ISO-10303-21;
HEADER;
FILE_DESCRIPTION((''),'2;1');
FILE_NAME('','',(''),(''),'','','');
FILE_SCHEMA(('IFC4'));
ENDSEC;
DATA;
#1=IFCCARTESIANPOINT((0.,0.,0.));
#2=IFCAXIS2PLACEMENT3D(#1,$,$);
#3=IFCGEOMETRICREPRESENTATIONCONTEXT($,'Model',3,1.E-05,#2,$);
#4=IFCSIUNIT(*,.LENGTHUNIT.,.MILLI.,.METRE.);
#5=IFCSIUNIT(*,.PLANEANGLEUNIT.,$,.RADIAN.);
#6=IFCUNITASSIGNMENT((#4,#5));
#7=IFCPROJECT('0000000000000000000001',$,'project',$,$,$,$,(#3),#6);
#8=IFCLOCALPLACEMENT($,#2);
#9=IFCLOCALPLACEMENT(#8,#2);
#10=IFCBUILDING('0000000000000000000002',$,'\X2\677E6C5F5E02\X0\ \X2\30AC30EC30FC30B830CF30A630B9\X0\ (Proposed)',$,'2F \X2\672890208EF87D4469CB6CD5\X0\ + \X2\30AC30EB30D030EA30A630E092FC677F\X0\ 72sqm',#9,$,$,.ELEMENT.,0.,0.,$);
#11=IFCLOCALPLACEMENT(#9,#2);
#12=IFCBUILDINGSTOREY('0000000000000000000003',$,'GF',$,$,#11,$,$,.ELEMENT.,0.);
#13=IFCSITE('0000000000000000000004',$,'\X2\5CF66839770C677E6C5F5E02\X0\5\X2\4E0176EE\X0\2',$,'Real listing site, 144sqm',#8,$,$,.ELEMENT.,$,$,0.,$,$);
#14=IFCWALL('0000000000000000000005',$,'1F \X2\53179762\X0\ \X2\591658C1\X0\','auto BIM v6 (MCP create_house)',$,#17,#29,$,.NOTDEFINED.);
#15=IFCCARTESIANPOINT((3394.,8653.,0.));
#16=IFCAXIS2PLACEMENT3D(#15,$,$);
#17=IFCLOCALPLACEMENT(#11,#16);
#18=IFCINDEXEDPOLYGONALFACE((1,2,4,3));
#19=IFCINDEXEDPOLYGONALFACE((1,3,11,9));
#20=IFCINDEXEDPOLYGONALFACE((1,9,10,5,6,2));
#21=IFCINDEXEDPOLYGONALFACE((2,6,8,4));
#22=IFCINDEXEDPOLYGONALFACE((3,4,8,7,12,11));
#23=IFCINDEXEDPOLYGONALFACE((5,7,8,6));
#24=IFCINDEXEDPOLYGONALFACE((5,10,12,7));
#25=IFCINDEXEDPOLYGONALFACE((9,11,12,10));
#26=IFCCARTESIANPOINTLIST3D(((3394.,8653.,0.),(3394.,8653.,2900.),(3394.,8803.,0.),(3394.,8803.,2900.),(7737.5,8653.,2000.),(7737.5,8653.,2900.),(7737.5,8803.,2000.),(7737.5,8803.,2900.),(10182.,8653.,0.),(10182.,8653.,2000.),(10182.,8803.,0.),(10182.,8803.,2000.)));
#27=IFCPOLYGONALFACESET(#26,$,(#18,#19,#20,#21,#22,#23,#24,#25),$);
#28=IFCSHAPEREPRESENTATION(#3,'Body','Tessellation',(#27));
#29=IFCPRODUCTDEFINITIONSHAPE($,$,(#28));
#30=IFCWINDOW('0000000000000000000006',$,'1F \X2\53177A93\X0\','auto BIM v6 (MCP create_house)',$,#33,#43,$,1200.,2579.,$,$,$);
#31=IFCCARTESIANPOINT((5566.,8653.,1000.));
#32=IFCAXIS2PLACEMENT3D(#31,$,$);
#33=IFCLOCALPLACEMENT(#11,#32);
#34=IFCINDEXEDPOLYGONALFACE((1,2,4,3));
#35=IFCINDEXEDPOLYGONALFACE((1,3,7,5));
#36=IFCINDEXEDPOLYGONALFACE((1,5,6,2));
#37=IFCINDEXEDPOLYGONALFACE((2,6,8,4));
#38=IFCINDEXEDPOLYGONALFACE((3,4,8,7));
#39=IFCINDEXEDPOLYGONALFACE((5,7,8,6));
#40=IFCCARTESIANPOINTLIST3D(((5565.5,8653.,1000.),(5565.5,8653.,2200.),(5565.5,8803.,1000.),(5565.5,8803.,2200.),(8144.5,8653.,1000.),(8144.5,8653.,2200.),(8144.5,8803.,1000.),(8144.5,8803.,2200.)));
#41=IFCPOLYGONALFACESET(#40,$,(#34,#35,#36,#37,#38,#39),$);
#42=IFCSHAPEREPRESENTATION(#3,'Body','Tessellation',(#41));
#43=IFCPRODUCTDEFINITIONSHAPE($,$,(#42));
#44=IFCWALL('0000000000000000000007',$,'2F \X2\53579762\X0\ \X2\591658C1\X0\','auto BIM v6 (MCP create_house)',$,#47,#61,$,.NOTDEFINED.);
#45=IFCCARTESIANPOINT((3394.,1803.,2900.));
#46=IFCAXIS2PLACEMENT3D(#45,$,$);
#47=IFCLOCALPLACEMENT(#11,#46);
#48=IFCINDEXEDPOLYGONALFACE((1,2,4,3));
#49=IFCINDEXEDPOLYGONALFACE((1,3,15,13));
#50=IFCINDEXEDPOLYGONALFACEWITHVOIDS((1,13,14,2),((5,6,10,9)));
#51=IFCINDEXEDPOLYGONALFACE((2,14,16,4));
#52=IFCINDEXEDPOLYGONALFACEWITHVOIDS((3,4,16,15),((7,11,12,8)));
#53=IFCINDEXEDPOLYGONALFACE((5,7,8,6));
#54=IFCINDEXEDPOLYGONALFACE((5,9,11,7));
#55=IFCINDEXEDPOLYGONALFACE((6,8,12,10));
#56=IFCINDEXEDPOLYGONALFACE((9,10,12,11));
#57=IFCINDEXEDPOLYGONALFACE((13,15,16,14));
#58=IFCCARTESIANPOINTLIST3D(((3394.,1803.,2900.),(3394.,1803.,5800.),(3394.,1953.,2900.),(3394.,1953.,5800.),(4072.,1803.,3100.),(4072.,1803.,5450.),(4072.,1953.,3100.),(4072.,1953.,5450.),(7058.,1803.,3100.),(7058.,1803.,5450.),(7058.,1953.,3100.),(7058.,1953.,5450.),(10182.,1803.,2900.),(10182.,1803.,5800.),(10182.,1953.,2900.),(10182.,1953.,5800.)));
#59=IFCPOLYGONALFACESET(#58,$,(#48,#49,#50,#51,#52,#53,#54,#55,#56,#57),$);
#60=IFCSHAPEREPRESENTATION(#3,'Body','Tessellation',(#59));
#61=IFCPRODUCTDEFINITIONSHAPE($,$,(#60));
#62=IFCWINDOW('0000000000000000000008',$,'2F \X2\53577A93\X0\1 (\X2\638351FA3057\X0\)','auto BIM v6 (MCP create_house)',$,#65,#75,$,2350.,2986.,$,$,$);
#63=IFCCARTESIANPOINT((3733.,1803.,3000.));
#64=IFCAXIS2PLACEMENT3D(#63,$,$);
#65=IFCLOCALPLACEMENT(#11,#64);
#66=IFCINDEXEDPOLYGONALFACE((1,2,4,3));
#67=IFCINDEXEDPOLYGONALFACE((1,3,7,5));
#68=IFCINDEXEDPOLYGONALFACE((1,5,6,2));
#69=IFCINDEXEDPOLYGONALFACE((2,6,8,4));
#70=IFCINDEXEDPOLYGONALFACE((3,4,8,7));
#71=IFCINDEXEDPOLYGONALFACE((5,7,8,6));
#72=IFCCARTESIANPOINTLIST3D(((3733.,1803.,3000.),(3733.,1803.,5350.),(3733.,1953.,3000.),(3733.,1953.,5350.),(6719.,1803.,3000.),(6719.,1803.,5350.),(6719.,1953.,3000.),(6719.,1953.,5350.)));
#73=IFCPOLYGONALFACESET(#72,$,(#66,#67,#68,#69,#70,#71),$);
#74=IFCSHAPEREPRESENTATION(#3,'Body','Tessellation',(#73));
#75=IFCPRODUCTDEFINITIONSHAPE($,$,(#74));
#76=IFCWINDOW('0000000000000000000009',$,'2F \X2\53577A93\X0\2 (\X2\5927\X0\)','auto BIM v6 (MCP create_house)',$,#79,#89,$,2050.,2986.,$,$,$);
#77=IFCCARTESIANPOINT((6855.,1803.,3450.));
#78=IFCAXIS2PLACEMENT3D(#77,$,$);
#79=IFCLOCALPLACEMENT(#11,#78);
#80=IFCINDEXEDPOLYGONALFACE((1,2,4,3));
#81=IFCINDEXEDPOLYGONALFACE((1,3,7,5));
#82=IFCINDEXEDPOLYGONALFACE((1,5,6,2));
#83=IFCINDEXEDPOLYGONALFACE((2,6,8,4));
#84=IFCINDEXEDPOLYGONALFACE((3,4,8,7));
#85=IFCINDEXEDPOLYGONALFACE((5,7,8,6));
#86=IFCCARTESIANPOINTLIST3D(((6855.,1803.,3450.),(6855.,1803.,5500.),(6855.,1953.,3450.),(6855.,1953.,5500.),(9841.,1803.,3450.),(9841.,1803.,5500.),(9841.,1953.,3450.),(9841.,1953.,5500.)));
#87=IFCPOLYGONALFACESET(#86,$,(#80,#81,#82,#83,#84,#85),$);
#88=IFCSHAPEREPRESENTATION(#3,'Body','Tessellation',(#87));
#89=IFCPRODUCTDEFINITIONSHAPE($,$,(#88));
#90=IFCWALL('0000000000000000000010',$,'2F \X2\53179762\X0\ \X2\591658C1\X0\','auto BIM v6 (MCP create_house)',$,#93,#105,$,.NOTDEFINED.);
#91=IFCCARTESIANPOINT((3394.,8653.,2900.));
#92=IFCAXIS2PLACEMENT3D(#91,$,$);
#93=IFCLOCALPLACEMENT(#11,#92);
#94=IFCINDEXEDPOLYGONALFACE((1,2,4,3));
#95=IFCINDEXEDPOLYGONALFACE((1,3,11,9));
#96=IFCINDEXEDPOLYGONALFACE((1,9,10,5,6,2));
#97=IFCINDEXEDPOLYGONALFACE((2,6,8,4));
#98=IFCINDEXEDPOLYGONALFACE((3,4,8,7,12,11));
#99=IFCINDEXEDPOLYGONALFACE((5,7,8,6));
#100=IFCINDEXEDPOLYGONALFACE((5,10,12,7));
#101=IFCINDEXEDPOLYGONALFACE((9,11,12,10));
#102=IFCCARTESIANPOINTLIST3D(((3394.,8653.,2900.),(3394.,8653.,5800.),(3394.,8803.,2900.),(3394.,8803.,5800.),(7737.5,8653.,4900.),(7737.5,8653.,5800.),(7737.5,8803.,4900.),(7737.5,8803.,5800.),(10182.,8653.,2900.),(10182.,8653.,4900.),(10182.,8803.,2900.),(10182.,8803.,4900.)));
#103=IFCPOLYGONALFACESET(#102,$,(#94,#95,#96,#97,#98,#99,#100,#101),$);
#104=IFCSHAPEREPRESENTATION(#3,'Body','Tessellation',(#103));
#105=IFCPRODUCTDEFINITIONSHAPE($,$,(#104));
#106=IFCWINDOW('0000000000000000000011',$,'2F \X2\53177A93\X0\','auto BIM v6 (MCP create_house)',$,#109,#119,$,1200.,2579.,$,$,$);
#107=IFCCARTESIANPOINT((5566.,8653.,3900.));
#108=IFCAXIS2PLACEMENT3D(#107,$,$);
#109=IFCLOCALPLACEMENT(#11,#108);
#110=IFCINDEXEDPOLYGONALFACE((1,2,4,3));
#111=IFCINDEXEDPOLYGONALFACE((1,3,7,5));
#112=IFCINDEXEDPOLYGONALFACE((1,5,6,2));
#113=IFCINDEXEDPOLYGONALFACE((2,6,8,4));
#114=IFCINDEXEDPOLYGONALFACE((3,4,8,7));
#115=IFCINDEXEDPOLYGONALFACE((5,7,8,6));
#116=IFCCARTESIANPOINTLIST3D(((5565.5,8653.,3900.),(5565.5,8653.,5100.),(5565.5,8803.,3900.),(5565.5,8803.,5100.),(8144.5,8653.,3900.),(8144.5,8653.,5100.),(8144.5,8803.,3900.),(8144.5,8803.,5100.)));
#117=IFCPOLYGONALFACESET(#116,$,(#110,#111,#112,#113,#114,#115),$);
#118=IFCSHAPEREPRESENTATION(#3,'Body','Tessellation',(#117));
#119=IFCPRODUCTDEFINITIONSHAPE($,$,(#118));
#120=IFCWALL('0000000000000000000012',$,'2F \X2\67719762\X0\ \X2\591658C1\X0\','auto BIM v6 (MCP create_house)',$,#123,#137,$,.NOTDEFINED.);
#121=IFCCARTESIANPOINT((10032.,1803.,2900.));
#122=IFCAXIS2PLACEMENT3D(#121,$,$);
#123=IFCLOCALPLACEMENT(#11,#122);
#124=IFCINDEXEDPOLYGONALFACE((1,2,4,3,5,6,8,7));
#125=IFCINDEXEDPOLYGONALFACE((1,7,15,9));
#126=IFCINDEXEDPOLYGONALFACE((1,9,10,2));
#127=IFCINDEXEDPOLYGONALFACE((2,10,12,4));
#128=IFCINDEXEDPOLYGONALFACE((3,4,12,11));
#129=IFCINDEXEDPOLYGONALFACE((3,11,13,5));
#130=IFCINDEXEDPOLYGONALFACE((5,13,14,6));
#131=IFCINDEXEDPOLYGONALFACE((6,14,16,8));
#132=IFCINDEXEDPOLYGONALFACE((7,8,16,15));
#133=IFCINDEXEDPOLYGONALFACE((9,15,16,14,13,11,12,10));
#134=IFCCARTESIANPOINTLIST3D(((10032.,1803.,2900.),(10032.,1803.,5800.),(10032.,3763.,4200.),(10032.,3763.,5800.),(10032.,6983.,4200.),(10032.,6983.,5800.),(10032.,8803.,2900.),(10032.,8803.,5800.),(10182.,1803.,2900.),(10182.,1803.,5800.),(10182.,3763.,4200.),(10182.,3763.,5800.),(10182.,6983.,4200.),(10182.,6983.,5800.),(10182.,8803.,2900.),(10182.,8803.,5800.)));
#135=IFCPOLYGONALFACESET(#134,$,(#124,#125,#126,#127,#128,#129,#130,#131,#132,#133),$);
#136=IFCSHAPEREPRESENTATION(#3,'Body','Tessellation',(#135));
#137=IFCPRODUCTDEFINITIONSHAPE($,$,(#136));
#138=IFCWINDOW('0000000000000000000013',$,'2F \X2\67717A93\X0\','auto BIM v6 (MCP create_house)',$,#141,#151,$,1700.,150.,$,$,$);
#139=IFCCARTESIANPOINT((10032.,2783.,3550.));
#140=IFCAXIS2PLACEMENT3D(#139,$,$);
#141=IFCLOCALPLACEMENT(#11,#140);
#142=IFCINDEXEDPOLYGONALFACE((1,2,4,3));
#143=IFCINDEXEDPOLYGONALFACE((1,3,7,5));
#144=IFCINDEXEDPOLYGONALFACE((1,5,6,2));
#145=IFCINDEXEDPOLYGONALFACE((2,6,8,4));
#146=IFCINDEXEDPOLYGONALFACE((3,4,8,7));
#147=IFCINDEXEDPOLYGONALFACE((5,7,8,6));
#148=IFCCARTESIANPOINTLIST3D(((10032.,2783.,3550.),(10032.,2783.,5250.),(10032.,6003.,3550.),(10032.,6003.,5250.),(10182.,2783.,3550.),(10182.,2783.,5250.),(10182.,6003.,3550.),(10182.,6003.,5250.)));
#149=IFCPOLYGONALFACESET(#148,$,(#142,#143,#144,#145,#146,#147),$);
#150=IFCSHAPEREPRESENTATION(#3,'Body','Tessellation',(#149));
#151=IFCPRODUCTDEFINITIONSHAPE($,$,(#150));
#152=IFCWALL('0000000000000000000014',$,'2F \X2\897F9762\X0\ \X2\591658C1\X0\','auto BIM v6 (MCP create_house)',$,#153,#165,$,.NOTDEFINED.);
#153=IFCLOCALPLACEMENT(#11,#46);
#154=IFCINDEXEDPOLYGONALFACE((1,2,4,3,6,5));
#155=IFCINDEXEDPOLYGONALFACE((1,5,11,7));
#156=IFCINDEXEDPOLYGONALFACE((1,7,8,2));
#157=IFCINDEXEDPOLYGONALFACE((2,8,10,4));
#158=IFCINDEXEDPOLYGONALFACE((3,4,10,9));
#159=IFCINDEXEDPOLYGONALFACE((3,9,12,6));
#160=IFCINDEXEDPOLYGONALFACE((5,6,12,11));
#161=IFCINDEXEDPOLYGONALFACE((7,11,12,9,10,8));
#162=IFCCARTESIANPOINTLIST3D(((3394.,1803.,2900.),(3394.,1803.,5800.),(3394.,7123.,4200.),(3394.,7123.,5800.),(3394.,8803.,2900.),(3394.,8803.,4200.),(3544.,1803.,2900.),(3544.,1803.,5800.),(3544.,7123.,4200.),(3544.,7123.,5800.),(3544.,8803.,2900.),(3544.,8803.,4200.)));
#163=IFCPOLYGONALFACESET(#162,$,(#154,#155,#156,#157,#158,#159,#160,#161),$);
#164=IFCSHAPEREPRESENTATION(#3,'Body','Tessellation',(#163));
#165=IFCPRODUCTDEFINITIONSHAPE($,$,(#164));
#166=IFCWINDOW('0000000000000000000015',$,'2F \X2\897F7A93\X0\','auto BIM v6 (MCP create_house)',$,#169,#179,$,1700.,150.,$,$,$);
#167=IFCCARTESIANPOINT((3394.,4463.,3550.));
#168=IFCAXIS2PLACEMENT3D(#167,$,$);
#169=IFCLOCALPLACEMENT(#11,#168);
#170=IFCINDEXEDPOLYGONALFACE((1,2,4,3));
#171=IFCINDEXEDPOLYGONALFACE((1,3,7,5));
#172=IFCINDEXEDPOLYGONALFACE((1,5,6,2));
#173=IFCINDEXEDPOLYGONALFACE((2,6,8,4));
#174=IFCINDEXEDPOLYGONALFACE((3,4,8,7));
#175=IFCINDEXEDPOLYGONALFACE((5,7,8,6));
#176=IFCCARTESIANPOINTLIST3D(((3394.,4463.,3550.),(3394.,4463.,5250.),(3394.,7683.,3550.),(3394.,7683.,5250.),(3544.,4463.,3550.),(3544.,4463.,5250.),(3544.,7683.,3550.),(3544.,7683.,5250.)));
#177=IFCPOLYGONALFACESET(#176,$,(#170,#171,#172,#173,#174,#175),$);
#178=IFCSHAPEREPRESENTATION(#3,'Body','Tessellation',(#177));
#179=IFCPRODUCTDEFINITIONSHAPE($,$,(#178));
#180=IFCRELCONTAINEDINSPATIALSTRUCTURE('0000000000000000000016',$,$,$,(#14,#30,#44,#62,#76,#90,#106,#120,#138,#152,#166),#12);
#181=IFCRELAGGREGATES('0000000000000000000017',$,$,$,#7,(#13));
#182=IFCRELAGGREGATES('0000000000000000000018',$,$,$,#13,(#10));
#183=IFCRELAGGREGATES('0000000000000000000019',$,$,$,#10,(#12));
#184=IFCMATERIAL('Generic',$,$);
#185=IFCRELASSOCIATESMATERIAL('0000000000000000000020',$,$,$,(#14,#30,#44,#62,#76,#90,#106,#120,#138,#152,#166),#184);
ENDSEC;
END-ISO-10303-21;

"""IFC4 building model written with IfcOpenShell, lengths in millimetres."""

from ifc_helpers import new_model, si_unit, frame, frame_2d, origin, place, context, project, spatial, rectangle, extrude, material, element, fill, save


model = new_model("IFC4")

# Units and contexts
model_context = context("Model", 3, precision=1e-05, world=origin())
ifc_project = project(units=[si_unit("LENGTHUNIT", "METRE", prefix="MILLI"), si_unit("PLANEANGLEUNIT", "RADIAN")], contexts=[model_context])

# Site, building, storey
site_placement = place(None, origin())
site = spatial("IfcSite", under=ifc_project, at=site_placement, Name="島根県松江市5丁目2", ObjectType="Real listing site, 144sqm", CompositionType="ELEMENT", RefElevation=0.0)
building_placement = place(site_placement, origin())
building = spatial("IfcBuilding", under=site, at=building_placement, Name="松江市 ガレージハウス (Proposed)", ObjectType="2F 木造軸組構法 + ガルバリウム鋼板 72sqm", CompositionType="ELEMENT", ElevationOfRefHeight=0.0, ElevationOfTerrain=0.0)
storey_placement = place(building_placement, origin())
storey = spatial("IfcBuildingStorey", under=building, at=storey_placement, Name="GF", CompositionType="ELEMENT", Elevation=0.0)

# Wall, opening, window
ifc_material = material(Name="Generic")
wall_1_placement = place(storey_placement, frame((3394.0, 8653.0, 0.0)))
wall_1 = element("IfcWall", 1, at=wall_1_placement, inside=storey, material=ifc_material, Name="1F 北面 外壁", Description="auto BIM v6 (MCP create_house)", PredefinedType="NOTDEFINED", context=model_context, shape_type="SweptSolid", body=[
    extrude(rectangle(XDim=6788.0, YDim=150.0, at=frame_2d((3394.0, 75.0))), frame((3394.0, 8653.0, 0.0)), (0.0, 0.0, 1.0), 2900.0),
])
opening_1_placement = place(storey_placement, frame((5566.0, 8653.0, 1000.0)))
opening_1 = element("IfcOpeningElement", 2, at=opening_1_placement, cuts=wall_1, PredefinedType="NOTDEFINED", context=model_context, shape_type="SweptSolid", body=[
    extrude(rectangle(XDim=2579.0, YDim=150.0, at=frame_2d((1289.0, 75.0))), frame((5566.0, 8653.0, 1000.0)), (0.0, 0.0, 1.0), 1200.0),
])
window_1_placement = place(storey_placement, frame((5566.0, 8653.0, 1000.0)))
window_1 = element("IfcWindow", 3, at=window_1_placement, inside=storey, material=ifc_material, Name="1F 北窓", Description="auto BIM v6 (MCP create_house)", OverallHeight=1200.0, OverallWidth=2579.0, context=model_context, shape_type="SweptSolid", body=[
    extrude(rectangle(XDim=2579.0, YDim=150.0, at=frame_2d((1289.0, 75.0))), frame((5566.0, 8653.0, 1000.0)), (0.0, 0.0, 1.0), 1200.0),
])
fill(opening_1, window_1)

# Wall, openings, windows
wall_2_placement = place(storey_placement, frame((3394.0, 1803.0, 2900.0)))
wall_2 = element("IfcWall", 4, at=wall_2_placement, inside=storey, material=ifc_material, Name="2F 南面 外壁", Description="auto BIM v6 (MCP create_house)", PredefinedType="NOTDEFINED", context=model_context, shape_type="SweptSolid", body=[
    extrude(rectangle(XDim=6788.0, YDim=150.0, at=frame_2d((3394.0, 75.0))), frame((3394.0, 1803.0, 2900.0)), (0.0, 0.0, 1.0), 2900.0),
])
opening_2_placement = place(storey_placement, frame((3733.0, 1803.0, 3000.0)))
opening_2 = element("IfcOpeningElement", 5, at=opening_2_placement, cuts=wall_2, PredefinedType="NOTDEFINED", context=model_context, shape_type="SweptSolid", body=[
    extrude(rectangle(XDim=2986.0, YDim=150.0, at=frame_2d((1493.0, 75.0))), frame((3733.0, 1803.0, 3000.0)), (0.0, 0.0, 1.0), 2350.0),
])
opening_3_placement = place(storey_placement, frame((6855.0, 1803.0, 3450.0)))
opening_3 = element("IfcOpeningElement", 6, at=opening_3_placement, cuts=wall_2, PredefinedType="NOTDEFINED", context=model_context, shape_type="SweptSolid", body=[
    extrude(rectangle(XDim=2986.0, YDim=150.0, at=frame_2d((1493.0, 75.0))), frame((6855.0, 1803.0, 3450.0)), (0.0, 0.0, 1.0), 2050.0),
])
window_2_placement = place(storey_placement, frame((3733.0, 1803.0, 3000.0)))
window_2 = element("IfcWindow", 7, at=window_2_placement, inside=storey, material=ifc_material, Name="2F 南窓1 (掃出し)", Description="auto BIM v6 (MCP create_house)", OverallHeight=2350.0, OverallWidth=2986.0, context=model_context, shape_type="SweptSolid", body=[
    extrude(rectangle(XDim=2986.0, YDim=150.0, at=frame_2d((1493.0, 75.0))), frame((3733.0, 1803.0, 3000.0)), (0.0, 0.0, 1.0), 2350.0),
])
fill(opening_2, window_2)
window_3_placement = place(storey_placement, frame((6855.0, 1803.0, 3450.0)))
window_3 = element("IfcWindow", 8, at=window_3_placement, inside=storey, material=ifc_material, Name="2F 南窓2 (大)", Description="auto BIM v6 (MCP create_house)", OverallHeight=2050.0, OverallWidth=2986.0, context=model_context, shape_type="SweptSolid", body=[
    extrude(rectangle(XDim=2986.0, YDim=150.0, at=frame_2d((1493.0, 75.0))), frame((6855.0, 1803.0, 3450.0)), (0.0, 0.0, 1.0), 2050.0),
])
fill(opening_3, window_3)

# Walls, openings, windows
wall_3_placement = place(storey_placement, frame((3394.0, 8653.0, 2900.0)))
wall_3 = element("IfcWall", 9, at=wall_3_placement, inside=storey, material=ifc_material, Name="2F 北面 外壁", Description="auto BIM v6 (MCP create_house)", PredefinedType="NOTDEFINED", context=model_context, shape_type="SweptSolid", body=[
    extrude(rectangle(XDim=6788.0, YDim=150.0, at=frame_2d((3394.0, 75.0))), frame((3394.0, 8653.0, 2900.0)), (0.0, 0.0, 1.0), 2900.0),
])
opening_4_placement = place(storey_placement, frame((5566.0, 8653.0, 3900.0)))
opening_4 = element("IfcOpeningElement", 10, at=opening_4_placement, cuts=wall_3, PredefinedType="NOTDEFINED", context=model_context, shape_type="SweptSolid", body=[
    extrude(rectangle(XDim=2579.0, YDim=150.0, at=frame_2d((1289.0, 75.0))), frame((5566.0, 8653.0, 3900.0)), (0.0, 0.0, 1.0), 1200.0),
])
window_4_placement = place(storey_placement, frame((5566.0, 8653.0, 3900.0)))
window_4 = element("IfcWindow", 11, at=window_4_placement, inside=storey, material=ifc_material, Name="2F 北窓", Description="auto BIM v6 (MCP create_house)", OverallHeight=1200.0, OverallWidth=2579.0, context=model_context, shape_type="SweptSolid", body=[
    extrude(rectangle(XDim=2579.0, YDim=150.0, at=frame_2d((1289.0, 75.0))), frame((5566.0, 8653.0, 3900.0)), (0.0, 0.0, 1.0), 1200.0),
])
fill(opening_4, window_4)
wall_4_placement = place(storey_placement, frame((10032.0, 1803.0, 2900.0)))
wall_4 = element("IfcWall", 12, at=wall_4_placement, inside=storey, material=ifc_material, Name="2F 東面 外壁", Description="auto BIM v6 (MCP create_house)", PredefinedType="NOTDEFINED", context=model_context, shape_type="SweptSolid", body=[
    extrude(rectangle(XDim=150.0, YDim=7000.0, at=frame_2d((75.0, 3500.0))), frame((10032.0, 1803.0, 2900.0)), (0.0, 0.0, 1.0), 2900.0),
])
opening_5_placement = place(storey_placement, frame((10032.0, 2783.0, 3550.0)))
opening_5 = element("IfcOpeningElement", 13, at=opening_5_placement, cuts=wall_4, PredefinedType="NOTDEFINED", context=model_context, shape_type="SweptSolid", body=[
    extrude(rectangle(XDim=150.0, YDim=3220.0, at=frame_2d((75.0, 1610.0))), frame((10032.0, 2783.0, 3550.0)), (0.0, 0.0, 1.0), 1700.0),
])
window_5_placement = place(storey_placement, frame((10032.0, 2783.0, 3550.0)))
window_5 = element("IfcWindow", 14, at=window_5_placement, inside=storey, material=ifc_material, Name="2F 東窓", Description="auto BIM v6 (MCP create_house)", OverallHeight=1700.0, OverallWidth=150.0, context=model_context, shape_type="SweptSolid", body=[
    extrude(rectangle(XDim=150.0, YDim=3220.0, at=frame_2d((75.0, 1610.0))), frame((10032.0, 2783.0, 3550.0)), (0.0, 0.0, 1.0), 1700.0),
])
fill(opening_5, window_5)
wall_5_placement = place(storey_placement, frame((3394.0, 1803.0, 2900.0)))
wall_5 = element("IfcWall", 15, at=wall_5_placement, inside=storey, material=ifc_material, Name="2F 西面 外壁", Description="auto BIM v6 (MCP create_house)", PredefinedType="NOTDEFINED", context=model_context, shape_type="SweptSolid", body=[
    extrude(rectangle(XDim=150.0, YDim=7000.0, at=frame_2d((75.0, 3500.0))), frame((3394.0, 1803.0, 2900.0)), (0.0, 0.0, 1.0), 2900.0),
])
opening_6_placement = place(storey_placement, frame((3394.0, 4463.0, 3550.0)))
opening_6 = element("IfcOpeningElement", 16, at=opening_6_placement, cuts=wall_5, PredefinedType="NOTDEFINED", context=model_context, shape_type="SweptSolid", body=[
    extrude(rectangle(XDim=150.0, YDim=3220.0, at=frame_2d((75.0, 1610.0))), frame((3394.0, 4463.0, 3550.0)), (0.0, 0.0, 1.0), 1700.0),
])
window_6_placement = place(storey_placement, frame((3394.0, 4463.0, 3550.0)))
window_6 = element("IfcWindow", 17, at=window_6_placement, inside=storey, material=ifc_material, Name="2F 西窓", Description="auto BIM v6 (MCP create_house)", OverallHeight=1700.0, OverallWidth=150.0, context=model_context, shape_type="SweptSolid", body=[
    extrude(rectangle(XDim=150.0, YDim=3220.0, at=frame_2d((75.0, 1610.0))), frame((3394.0, 4463.0, 3550.0)), (0.0, 0.0, 1.0), 1700.0),
])
fill(opening_6, window_6)

save(model, "model.ifc")
